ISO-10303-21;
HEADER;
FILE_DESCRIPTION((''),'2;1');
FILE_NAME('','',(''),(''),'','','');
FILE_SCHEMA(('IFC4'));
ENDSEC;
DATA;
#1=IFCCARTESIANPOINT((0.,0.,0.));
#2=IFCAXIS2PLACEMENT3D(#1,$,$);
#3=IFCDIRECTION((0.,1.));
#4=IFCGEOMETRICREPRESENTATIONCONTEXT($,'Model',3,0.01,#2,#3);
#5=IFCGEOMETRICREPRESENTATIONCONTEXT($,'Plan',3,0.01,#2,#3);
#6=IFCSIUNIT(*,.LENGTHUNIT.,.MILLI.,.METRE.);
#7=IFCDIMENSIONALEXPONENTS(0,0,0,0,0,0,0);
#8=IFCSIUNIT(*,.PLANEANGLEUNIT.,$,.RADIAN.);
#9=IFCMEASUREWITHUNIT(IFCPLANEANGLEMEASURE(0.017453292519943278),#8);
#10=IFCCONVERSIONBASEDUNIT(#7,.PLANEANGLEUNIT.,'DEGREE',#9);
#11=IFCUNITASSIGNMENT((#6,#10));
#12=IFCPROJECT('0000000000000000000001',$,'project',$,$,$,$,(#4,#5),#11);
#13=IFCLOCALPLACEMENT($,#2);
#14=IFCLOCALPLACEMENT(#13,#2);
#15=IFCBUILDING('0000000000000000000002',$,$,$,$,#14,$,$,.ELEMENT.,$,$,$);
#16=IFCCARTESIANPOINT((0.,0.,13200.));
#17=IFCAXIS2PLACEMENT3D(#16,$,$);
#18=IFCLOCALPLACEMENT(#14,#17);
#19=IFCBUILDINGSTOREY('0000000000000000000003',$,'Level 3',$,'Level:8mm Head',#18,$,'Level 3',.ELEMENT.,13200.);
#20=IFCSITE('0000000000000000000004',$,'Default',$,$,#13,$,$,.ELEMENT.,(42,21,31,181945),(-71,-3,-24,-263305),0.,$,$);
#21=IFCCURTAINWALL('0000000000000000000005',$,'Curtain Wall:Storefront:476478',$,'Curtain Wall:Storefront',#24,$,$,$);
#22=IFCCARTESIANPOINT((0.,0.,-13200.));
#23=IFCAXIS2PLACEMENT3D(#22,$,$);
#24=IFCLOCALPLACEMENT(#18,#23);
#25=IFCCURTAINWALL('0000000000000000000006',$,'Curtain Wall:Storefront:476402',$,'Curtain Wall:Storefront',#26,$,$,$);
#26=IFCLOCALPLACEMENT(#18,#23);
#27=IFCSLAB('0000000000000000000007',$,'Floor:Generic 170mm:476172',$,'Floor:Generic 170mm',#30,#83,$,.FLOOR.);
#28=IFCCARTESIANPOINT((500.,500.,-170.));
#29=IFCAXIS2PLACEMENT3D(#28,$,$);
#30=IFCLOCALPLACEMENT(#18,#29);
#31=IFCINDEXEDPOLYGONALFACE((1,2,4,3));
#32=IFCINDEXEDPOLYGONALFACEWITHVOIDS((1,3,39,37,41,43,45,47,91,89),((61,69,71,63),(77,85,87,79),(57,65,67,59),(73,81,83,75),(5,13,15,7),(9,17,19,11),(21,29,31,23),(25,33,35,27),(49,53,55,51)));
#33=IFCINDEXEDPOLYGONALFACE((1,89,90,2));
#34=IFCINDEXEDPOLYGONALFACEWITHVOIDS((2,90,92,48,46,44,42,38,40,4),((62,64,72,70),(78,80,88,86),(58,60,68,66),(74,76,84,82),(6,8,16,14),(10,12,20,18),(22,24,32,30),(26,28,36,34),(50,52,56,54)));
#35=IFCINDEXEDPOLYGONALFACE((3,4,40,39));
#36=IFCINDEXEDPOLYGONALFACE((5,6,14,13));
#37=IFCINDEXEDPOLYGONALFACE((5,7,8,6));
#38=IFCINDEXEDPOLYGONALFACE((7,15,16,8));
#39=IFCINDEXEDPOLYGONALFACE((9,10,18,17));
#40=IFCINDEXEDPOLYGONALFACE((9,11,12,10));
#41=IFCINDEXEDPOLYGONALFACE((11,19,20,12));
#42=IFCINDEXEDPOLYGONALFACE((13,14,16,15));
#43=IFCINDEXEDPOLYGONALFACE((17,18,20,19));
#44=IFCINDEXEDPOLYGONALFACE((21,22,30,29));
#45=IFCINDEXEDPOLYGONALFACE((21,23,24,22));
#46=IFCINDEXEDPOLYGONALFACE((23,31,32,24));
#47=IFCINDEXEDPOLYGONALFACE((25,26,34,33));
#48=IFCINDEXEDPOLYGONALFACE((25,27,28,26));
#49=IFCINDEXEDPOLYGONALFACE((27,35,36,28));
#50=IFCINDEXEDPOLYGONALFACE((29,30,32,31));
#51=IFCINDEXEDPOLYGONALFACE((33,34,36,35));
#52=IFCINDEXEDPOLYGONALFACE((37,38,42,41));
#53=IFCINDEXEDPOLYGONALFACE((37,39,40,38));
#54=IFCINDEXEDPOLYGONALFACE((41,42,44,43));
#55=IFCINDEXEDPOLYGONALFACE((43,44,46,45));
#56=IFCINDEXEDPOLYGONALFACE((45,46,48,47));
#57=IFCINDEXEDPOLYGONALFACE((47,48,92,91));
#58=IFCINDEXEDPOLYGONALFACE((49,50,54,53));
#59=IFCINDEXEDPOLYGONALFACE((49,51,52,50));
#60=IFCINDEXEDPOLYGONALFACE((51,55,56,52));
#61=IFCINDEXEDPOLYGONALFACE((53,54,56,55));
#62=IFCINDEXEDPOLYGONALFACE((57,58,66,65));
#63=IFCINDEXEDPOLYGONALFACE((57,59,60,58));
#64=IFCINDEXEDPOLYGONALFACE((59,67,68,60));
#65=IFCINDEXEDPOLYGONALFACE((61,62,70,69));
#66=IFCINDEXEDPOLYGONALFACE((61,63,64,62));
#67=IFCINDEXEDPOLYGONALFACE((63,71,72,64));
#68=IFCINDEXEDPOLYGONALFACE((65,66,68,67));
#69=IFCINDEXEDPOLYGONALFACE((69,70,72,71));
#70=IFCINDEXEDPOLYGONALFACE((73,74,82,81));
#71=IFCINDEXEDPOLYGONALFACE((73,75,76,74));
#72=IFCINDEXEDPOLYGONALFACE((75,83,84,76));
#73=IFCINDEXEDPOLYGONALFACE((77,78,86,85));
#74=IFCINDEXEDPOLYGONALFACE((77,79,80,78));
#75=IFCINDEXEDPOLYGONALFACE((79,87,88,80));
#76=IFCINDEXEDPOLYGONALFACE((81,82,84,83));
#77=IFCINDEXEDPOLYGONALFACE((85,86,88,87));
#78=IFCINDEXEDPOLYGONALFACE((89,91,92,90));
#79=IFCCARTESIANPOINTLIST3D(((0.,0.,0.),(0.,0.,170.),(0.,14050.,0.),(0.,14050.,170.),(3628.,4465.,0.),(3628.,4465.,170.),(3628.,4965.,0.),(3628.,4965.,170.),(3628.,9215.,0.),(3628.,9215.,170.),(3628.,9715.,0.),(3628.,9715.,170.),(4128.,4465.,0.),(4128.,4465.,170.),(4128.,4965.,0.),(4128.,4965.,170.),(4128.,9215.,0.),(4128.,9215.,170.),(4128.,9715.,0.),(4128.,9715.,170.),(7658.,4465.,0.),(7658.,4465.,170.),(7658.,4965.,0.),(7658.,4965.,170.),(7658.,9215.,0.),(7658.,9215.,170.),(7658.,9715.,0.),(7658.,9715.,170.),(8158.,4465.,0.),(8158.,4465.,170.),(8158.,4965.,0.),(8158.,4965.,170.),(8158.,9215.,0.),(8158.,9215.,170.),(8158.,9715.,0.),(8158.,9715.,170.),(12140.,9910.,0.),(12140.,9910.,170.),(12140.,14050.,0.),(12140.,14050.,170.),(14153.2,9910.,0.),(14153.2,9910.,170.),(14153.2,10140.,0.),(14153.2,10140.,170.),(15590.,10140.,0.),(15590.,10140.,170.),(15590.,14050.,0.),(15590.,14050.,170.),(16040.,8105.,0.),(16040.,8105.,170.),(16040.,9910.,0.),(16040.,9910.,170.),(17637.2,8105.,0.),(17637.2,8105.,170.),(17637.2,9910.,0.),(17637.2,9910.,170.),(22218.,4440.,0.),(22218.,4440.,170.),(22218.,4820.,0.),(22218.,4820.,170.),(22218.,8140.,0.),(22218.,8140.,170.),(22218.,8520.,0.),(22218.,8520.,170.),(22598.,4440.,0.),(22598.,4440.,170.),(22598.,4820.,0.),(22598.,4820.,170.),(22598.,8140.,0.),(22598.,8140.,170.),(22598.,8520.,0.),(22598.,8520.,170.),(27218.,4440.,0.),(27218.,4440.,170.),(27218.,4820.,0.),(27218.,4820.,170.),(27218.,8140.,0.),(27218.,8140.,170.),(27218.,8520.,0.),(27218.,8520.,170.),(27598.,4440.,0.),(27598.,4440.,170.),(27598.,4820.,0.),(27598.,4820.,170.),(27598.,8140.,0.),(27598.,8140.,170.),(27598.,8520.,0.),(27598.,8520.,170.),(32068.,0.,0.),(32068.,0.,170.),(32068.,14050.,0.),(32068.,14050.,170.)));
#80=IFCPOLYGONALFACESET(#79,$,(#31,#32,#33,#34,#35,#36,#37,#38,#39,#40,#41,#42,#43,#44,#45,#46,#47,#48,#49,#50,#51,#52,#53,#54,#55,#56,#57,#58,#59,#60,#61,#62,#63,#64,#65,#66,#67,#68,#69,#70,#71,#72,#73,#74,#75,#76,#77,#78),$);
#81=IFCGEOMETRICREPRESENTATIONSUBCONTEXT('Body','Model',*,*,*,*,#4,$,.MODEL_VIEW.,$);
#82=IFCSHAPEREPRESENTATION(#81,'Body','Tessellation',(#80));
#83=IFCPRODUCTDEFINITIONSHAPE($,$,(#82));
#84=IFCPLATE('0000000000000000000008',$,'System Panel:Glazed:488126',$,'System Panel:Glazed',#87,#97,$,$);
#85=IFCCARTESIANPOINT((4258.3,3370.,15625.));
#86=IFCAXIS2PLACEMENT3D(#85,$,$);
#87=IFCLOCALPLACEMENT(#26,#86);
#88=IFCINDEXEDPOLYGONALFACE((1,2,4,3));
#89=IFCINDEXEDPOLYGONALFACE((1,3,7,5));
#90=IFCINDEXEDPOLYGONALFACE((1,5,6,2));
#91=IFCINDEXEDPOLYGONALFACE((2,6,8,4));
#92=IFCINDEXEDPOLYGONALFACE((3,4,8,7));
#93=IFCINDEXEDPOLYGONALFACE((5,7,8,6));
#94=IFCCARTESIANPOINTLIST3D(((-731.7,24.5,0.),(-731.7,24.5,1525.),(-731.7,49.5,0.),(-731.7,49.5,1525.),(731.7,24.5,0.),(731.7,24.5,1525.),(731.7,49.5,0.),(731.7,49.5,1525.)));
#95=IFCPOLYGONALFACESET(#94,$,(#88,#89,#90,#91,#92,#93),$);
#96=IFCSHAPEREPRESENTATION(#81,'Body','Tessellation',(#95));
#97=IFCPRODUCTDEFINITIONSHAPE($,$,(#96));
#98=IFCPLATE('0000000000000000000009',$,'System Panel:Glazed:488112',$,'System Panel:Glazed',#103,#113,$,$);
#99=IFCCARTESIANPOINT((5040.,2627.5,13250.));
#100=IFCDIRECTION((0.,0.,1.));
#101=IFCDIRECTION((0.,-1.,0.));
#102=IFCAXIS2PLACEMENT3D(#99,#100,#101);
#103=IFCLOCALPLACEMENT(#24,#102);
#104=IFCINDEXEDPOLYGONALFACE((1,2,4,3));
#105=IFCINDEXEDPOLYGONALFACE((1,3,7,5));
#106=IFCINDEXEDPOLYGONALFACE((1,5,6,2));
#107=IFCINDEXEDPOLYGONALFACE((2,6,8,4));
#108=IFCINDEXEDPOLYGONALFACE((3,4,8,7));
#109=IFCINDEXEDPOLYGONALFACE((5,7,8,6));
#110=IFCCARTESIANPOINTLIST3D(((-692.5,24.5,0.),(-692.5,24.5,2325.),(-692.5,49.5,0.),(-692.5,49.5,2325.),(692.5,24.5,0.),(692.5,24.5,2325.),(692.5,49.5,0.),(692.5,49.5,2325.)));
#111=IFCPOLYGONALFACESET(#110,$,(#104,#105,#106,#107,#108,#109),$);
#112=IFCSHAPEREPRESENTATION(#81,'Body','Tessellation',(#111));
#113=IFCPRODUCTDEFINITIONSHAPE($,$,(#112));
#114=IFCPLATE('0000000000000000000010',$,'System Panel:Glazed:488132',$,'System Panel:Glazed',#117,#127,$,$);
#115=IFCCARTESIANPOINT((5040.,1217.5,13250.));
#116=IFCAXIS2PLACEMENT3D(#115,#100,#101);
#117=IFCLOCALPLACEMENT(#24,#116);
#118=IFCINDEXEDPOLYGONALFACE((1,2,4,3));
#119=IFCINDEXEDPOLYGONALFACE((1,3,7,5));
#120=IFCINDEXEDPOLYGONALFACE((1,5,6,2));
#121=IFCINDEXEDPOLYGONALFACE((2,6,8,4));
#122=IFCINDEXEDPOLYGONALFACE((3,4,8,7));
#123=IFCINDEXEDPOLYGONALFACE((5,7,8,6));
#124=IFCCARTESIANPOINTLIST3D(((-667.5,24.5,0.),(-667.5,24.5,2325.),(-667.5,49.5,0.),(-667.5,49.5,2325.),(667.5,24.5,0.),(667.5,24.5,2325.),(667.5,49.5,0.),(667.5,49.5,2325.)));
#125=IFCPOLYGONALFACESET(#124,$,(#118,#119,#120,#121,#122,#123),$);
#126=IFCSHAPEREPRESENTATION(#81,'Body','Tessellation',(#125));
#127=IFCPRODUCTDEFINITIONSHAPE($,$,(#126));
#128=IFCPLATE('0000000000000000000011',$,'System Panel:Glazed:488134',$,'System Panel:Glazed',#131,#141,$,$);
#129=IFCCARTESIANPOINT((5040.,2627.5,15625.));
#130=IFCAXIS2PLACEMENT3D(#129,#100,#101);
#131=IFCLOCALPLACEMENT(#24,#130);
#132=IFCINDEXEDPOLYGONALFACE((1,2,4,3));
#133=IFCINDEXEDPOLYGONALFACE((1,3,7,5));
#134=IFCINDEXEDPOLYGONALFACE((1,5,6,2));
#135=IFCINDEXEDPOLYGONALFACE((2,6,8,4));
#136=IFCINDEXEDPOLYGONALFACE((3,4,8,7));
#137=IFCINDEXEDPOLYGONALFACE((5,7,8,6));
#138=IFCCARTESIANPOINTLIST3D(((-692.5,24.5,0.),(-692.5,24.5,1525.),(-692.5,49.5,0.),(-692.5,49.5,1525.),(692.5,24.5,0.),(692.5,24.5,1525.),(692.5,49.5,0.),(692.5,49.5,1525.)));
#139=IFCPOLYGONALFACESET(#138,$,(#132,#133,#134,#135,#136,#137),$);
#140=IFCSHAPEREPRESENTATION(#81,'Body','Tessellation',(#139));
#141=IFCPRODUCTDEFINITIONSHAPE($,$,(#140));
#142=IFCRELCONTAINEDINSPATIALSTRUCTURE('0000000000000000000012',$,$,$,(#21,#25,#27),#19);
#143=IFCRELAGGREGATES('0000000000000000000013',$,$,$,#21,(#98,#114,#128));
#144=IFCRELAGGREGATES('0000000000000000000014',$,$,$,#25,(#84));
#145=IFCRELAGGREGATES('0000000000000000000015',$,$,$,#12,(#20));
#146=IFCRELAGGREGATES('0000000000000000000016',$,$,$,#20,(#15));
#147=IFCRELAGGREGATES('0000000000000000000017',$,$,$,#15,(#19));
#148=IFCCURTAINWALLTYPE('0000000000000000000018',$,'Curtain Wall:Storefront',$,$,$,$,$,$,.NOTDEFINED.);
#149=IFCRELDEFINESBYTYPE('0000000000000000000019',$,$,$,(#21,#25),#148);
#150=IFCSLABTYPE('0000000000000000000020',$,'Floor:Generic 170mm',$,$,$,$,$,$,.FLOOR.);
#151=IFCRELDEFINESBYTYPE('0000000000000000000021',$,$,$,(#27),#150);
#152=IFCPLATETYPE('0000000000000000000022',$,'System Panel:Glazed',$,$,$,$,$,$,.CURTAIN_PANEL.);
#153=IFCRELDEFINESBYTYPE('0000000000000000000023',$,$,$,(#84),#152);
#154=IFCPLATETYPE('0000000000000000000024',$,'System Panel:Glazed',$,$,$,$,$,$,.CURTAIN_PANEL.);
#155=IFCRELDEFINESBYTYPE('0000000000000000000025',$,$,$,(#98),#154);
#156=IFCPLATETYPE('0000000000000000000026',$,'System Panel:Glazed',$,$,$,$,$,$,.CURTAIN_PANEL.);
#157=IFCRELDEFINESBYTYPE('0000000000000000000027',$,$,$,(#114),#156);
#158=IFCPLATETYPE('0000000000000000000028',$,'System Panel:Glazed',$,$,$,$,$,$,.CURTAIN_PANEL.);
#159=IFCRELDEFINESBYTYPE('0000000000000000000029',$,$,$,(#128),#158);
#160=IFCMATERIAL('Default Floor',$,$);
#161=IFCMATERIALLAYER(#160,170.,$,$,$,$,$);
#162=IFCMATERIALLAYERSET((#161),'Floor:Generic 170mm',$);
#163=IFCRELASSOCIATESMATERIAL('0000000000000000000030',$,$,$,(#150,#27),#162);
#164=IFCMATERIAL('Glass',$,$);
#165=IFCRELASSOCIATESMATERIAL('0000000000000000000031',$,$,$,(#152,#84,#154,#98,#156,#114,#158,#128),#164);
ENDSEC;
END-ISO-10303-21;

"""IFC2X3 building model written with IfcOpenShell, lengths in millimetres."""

from ifc_helpers import new_model, entity, si_unit, converted_unit, direction, frame, frame_2d, origin, origin_2d_with_axis, place, context, subcontext, project, spatial, polyline, rectangle, outline, extrude, source, transform, mapped, material, layer, layer_set, layer_usage, type_object, type_shapes, element, aggregate, save


model = new_model("IFC2X3")

# Units and contexts
model_context = context("Model", 3, precision=0.01, world=origin(), true_north=direction((0.0, 1.0)))
plan_context = context("Plan", 3, precision=0.01, world=origin(), true_north=direction((0.0, 1.0)))
body_context = subcontext(model_context, "Body", "Model", "MODEL_VIEW")
ifc_project = project(units=[si_unit("LENGTHUNIT", "METRE", prefix="MILLI"), converted_unit("PLANEANGLEUNIT", "DEGREE", entity("IfcPlaneAngleMeasure", 0.017453292519943278), si_unit("PLANEANGLEUNIT", "RADIAN"), dimensions=[0, 0, 0, 0, 0, 0, 0])], contexts=[model_context, plan_context])

# Site, building, storey
site_placement = place(None, origin())
site = spatial("IfcSite", under=ifc_project, at=site_placement, Name="Default", CompositionType="ELEMENT", RefLatitude=(42, 21, 31, 181945), RefLongitude=(-71, -3, -24, -263305), RefElevation=0.0)
building_placement = place(site_placement, origin())
building = spatial("IfcBuilding", under=site, at=building_placement, CompositionType="ELEMENT")
storey_placement = place(building_placement, frame((0.0, 0.0, 13200.0)))
storey = spatial("IfcBuildingStorey", under=building, at=storey_placement, Name="Level 3", ObjectType="Level:8mm Head", LongName="Level 3", CompositionType="ELEMENT", Elevation=13200.0)

# Curtain walls
curtain_wall_type = type_object("IfcCurtainWallType", Name="Curtain Wall:Storefront", PredefinedType="NOTDEFINED")
curtain_wall_1_placement = place(storey_placement, frame((0.0, 0.0, -13200.0)))
curtain_wall_1 = element("IfcCurtainWall", 1, at=curtain_wall_1_placement, inside=storey, type_object=curtain_wall_type, Name="Curtain Wall:Storefront:476478", ObjectType="Curtain Wall:Storefront")
curtain_wall_2_placement = place(storey_placement, frame((0.0, 0.0, -13200.0)))
curtain_wall_2 = element("IfcCurtainWall", 2, at=curtain_wall_2_placement, inside=storey, type_object=curtain_wall_type, Name="Curtain Wall:Storefront:476402", ObjectType="Curtain Wall:Storefront")

# Slab, openings
ifc_material_1 = material(Name="Default Floor")
ifc_layer = layer(ifc_material_1, 170.0)
ifc_layer_set = layer_set([ifc_layer], Name="Floor:Generic 170mm")
ifc_layer_usage = layer_usage(ifc_layer_set, "AXIS3", "POSITIVE", 0.0)
slab_type = type_object("IfcSlabType", Name="Floor:Generic 170mm", PredefinedType="FLOOR", material=ifc_layer_set)
slab_placement = place(storey_placement, frame((500.0, 500.0, -170.0)))
slab = element("IfcSlab", 3, at=slab_placement, inside=storey, type_object=slab_type, material=ifc_layer_usage, Name="Floor:Generic 170mm:476172", ObjectType="Floor:Generic 170mm", PredefinedType="FLOOR", context=body_context, shape_type="SweptSolid", body=[
    extrude(outline(polyline([(3894.0, 7025.0), (3894.0, 2885.0), (1880.8, 2885.0), (1880.8, 3115.0), (444.0, 3115.0), (444.0, 7025.0), (-16034.0, 7025.0), (-16034.0, -7025.0), (16034.0, -7025.0), (16034.0, 7025.0), (3894.0, 7025.0)])), frame((16034.0, 7025.0, 170.0), z_axis=(0.0, 0.0, -1.0), x_axis=(-1.0, 0.0, 0.0)), (0.0, 0.0, 1.0), 170.0),
])
opening_1_placement = place(slab_placement, origin())
element("IfcOpeningElement", 4, at=opening_1_placement, cuts=slab, ObjectType="Opening", context=body_context, shape_type="SweptSolid", body=[
    extrude(rectangle(XDim=1805.0, YDim=1597.2, at=origin_2d_with_axis()), frame((16838.6, 9007.5, 170.0), z_axis=(0.0, 0.0, -1.0), x_axis=(0.0, -1.0, 0.0)), (0.0, 0.0, 1.0), 170.0),
])
opening_2_placement = place(slab_placement, origin())
element("IfcOpeningElement", 5, at=opening_2_placement, cuts=slab, ObjectType="Opening", context=body_context, shape_type="SweptSolid", body=[
    extrude(rectangle(XDim=500.0, YDim=500.0, at=frame_2d((0.0, 0.0), x_axis=(1.0, 0.0))), frame((3878.0, 9465.0, 170.0), z_axis=(0.0, 0.0, -1.0), x_axis=(0.0, -1.0, 0.0)), (0.0, 0.0, 1.0), 170.0),
])
opening_3_placement = place(slab_placement, origin())
element("IfcOpeningElement", 6, at=opening_3_placement, cuts=slab, ObjectType="Opening", context=body_context, shape_type="SweptSolid", body=[
    extrude(rectangle(XDim=500.0, YDim=500.0, at=frame_2d((0.0, 0.0), x_axis=(1.0, 0.0))), frame((7908.0, 9465.0, 170.0), z_axis=(0.0, 0.0, -1.0), x_axis=(0.0, -1.0, 0.0)), (0.0, 0.0, 1.0), 170.0),
])
opening_4_placement = place(slab_placement, origin())
element("IfcOpeningElement", 7, at=opening_4_placement, cuts=slab, ObjectType="Opening", context=body_context, shape_type="SweptSolid", body=[
    extrude(rectangle(XDim=500.0, YDim=500.0, at=origin_2d_with_axis()), frame((3878.0, 4715.0, 170.0), z_axis=(0.0, 0.0, -1.0), x_axis=(0.0, -1.0, 0.0)), (0.0, 0.0, 1.0), 170.0),
])
opening_5_placement = place(slab_placement, origin())
element("IfcOpeningElement", 8, at=opening_5_placement, cuts=slab, ObjectType="Opening", context=body_context, shape_type="SweptSolid", body=[
    extrude(rectangle(XDim=500.0, YDim=500.0, at=frame_2d((0.0, 0.0), x_axis=(1.0, 0.0))), frame((7908.0, 4715.0, 170.0), z_axis=(0.0, 0.0, -1.0), x_axis=(0.0, -1.0, 0.0)), (0.0, 0.0, 1.0), 170.0),
])
opening_6_placement = place(slab_placement, origin())
element("IfcOpeningElement", 9, at=opening_6_placement, cuts=slab, ObjectType="Opening", context=body_context, shape_type="SweptSolid", body=[
    extrude(rectangle(XDim=380.0, YDim=380.0, at=frame_2d((0.0, 0.0), x_axis=(1.0, 0.0))), frame((27408.0, 8330.0, 170.0), z_axis=(0.0, 0.0, -1.0), x_axis=(1.0, 0.0, 0.0)), (0.0, 0.0, 1.0), 170.0),
])
opening_7_placement = place(slab_placement, origin())
element("IfcOpeningElement", 10, at=opening_7_placement, cuts=slab, ObjectType="Opening", context=body_context, shape_type="SweptSolid", body=[
    extrude(rectangle(XDim=380.0, YDim=380.0, at=origin_2d_with_axis()), frame((27408.0, 4630.0, 170.0), z_axis=(0.0, 0.0, -1.0), x_axis=(-1.0, 0.0, 0.0)), (0.0, 0.0, 1.0), 170.0),
])
opening_8_placement = place(slab_placement, origin())
element("IfcOpeningElement", 11, at=opening_8_placement, cuts=slab, ObjectType="Opening", context=body_context, shape_type="SweptSolid", body=[
    extrude(rectangle(XDim=380.0, YDim=380.0, at=frame_2d((0.0, 0.0), x_axis=(1.0, 0.0))), frame((22408.0, 8330.0, 170.0), z_axis=(0.0, 0.0, -1.0), x_axis=(1.0, 0.0, 0.0)), (0.0, 0.0, 1.0), 170.0),
])
opening_9_placement = place(slab_placement, origin())
element("IfcOpeningElement", 12, at=opening_9_placement, cuts=slab, ObjectType="Opening", context=body_context, shape_type="SweptSolid", body=[
    extrude(rectangle(XDim=380.0, YDim=380.0, at=origin_2d_with_axis()), frame((22408.0, 4630.0, 170.0), z_axis=(0.0, 0.0, -1.0), x_axis=(-1.0, 0.0, 0.0)), (0.0, 0.0, 1.0), 170.0),
])

# Plates
ifc_material_2 = material(Name="Glass")
plate_type_1 = type_object("IfcPlateType", Name="System Panel:Glazed", PredefinedType="CURTAIN_PANEL", material=ifc_material_2)
shared_shape_1 = source(origin(), body_context, "Body", "SweptSolid", [
    extrude(rectangle(XDim=25.0, YDim=1463.3, at=origin_2d_with_axis()), frame((0.0, 37.0, 0.0), z_axis=(0.0, 0.0, 1.0), x_axis=(0.0, 1.0, 0.0)), (0.0, 0.0, 1.0), 1525.0),
])
type_shapes(plate_type_1, [shared_shape_1])
plate_1_placement = place(curtain_wall_2_placement, frame((4258.3, 3370.0, 15625.0)))
plate_1 = element("IfcPlate", 13, at=plate_1_placement, type_object=plate_type_1, material=ifc_material_2, Name="System Panel:Glazed:488126", ObjectType="System Panel:Glazed", context=body_context, shape_type="MappedRepresentation", body=[
    mapped(shared_shape_1, transform((0.0, 0.0, 0.0), scale=1.0)),
])
plate_type_2 = type_object("IfcPlateType", Name="System Panel:Glazed", PredefinedType="CURTAIN_PANEL", material=ifc_material_2)
shared_shape_2 = source(origin(), body_context, "Body", "SweptSolid", [
    extrude(rectangle(XDim=25.0, YDim=1385.0, at=origin_2d_with_axis()), frame((0.0, 37.0, 0.0), z_axis=(0.0, 0.0, 1.0), x_axis=(0.0, 1.0, 0.0)), (0.0, 0.0, 1.0), 2325.0),
])
type_shapes(plate_type_2, [shared_shape_2])
plate_2_placement = place(curtain_wall_1_placement, frame((5040.0, 2627.5, 13250.0), z_axis=(0.0, 0.0, 1.0), x_axis=(0.0, -1.0, 0.0)))
plate_2 = element("IfcPlate", 14, at=plate_2_placement, type_object=plate_type_2, material=ifc_material_2, Name="System Panel:Glazed:488112", ObjectType="System Panel:Glazed", context=body_context, shape_type="MappedRepresentation", body=[
    mapped(shared_shape_2, transform((0.0, 0.0, 0.0), scale=1.0)),
])
plate_type_3 = type_object("IfcPlateType", Name="System Panel:Glazed", PredefinedType="CURTAIN_PANEL", material=ifc_material_2)
shared_shape_3 = source(origin(), body_context, "Body", "SweptSolid", [
    extrude(rectangle(XDim=25.0, YDim=1335.0, at=origin_2d_with_axis()), frame((0.0, 37.0, 0.0), z_axis=(0.0, 0.0, 1.0), x_axis=(0.0, 1.0, 0.0)), (0.0, 0.0, 1.0), 2325.0),
])
type_shapes(plate_type_3, [shared_shape_3])
plate_3_placement = place(curtain_wall_1_placement, frame((5040.0, 1217.5, 13250.0), z_axis=(0.0, 0.0, 1.0), x_axis=(0.0, -1.0, 0.0)))
plate_3 = element("IfcPlate", 15, at=plate_3_placement, type_object=plate_type_3, material=ifc_material_2, Name="System Panel:Glazed:488132", ObjectType="System Panel:Glazed", context=body_context, shape_type="MappedRepresentation", body=[
    mapped(shared_shape_3, transform((0.0, 0.0, 0.0), scale=1.0)),
])
plate_type_4 = type_object("IfcPlateType", Name="System Panel:Glazed", PredefinedType="CURTAIN_PANEL", material=ifc_material_2)
shared_shape_4 = source(origin(), body_context, "Body", "SweptSolid", [
    extrude(rectangle(XDim=25.0, YDim=1385.0, at=origin_2d_with_axis()), frame((0.0, 37.0, 0.0), z_axis=(0.0, 0.0, 1.0), x_axis=(0.0, 1.0, 0.0)), (0.0, 0.0, 1.0), 1525.0),
])
type_shapes(plate_type_4, [shared_shape_4])
plate_4_placement = place(curtain_wall_1_placement, frame((5040.0, 2627.5, 15625.0), z_axis=(0.0, 0.0, 1.0), x_axis=(0.0, -1.0, 0.0)))
plate_4 = element("IfcPlate", 16, at=plate_4_placement, type_object=plate_type_4, material=ifc_material_2, Name="System Panel:Glazed:488134", ObjectType="System Panel:Glazed", context=body_context, shape_type="MappedRepresentation", body=[
    mapped(shared_shape_4, transform((0.0, 0.0, 0.0), scale=1.0)),
])
aggregate(curtain_wall_1, [plate_2, plate_3, plate_4])

aggregate(curtain_wall_2, [plate_1])

save(model, "model.ifc")
